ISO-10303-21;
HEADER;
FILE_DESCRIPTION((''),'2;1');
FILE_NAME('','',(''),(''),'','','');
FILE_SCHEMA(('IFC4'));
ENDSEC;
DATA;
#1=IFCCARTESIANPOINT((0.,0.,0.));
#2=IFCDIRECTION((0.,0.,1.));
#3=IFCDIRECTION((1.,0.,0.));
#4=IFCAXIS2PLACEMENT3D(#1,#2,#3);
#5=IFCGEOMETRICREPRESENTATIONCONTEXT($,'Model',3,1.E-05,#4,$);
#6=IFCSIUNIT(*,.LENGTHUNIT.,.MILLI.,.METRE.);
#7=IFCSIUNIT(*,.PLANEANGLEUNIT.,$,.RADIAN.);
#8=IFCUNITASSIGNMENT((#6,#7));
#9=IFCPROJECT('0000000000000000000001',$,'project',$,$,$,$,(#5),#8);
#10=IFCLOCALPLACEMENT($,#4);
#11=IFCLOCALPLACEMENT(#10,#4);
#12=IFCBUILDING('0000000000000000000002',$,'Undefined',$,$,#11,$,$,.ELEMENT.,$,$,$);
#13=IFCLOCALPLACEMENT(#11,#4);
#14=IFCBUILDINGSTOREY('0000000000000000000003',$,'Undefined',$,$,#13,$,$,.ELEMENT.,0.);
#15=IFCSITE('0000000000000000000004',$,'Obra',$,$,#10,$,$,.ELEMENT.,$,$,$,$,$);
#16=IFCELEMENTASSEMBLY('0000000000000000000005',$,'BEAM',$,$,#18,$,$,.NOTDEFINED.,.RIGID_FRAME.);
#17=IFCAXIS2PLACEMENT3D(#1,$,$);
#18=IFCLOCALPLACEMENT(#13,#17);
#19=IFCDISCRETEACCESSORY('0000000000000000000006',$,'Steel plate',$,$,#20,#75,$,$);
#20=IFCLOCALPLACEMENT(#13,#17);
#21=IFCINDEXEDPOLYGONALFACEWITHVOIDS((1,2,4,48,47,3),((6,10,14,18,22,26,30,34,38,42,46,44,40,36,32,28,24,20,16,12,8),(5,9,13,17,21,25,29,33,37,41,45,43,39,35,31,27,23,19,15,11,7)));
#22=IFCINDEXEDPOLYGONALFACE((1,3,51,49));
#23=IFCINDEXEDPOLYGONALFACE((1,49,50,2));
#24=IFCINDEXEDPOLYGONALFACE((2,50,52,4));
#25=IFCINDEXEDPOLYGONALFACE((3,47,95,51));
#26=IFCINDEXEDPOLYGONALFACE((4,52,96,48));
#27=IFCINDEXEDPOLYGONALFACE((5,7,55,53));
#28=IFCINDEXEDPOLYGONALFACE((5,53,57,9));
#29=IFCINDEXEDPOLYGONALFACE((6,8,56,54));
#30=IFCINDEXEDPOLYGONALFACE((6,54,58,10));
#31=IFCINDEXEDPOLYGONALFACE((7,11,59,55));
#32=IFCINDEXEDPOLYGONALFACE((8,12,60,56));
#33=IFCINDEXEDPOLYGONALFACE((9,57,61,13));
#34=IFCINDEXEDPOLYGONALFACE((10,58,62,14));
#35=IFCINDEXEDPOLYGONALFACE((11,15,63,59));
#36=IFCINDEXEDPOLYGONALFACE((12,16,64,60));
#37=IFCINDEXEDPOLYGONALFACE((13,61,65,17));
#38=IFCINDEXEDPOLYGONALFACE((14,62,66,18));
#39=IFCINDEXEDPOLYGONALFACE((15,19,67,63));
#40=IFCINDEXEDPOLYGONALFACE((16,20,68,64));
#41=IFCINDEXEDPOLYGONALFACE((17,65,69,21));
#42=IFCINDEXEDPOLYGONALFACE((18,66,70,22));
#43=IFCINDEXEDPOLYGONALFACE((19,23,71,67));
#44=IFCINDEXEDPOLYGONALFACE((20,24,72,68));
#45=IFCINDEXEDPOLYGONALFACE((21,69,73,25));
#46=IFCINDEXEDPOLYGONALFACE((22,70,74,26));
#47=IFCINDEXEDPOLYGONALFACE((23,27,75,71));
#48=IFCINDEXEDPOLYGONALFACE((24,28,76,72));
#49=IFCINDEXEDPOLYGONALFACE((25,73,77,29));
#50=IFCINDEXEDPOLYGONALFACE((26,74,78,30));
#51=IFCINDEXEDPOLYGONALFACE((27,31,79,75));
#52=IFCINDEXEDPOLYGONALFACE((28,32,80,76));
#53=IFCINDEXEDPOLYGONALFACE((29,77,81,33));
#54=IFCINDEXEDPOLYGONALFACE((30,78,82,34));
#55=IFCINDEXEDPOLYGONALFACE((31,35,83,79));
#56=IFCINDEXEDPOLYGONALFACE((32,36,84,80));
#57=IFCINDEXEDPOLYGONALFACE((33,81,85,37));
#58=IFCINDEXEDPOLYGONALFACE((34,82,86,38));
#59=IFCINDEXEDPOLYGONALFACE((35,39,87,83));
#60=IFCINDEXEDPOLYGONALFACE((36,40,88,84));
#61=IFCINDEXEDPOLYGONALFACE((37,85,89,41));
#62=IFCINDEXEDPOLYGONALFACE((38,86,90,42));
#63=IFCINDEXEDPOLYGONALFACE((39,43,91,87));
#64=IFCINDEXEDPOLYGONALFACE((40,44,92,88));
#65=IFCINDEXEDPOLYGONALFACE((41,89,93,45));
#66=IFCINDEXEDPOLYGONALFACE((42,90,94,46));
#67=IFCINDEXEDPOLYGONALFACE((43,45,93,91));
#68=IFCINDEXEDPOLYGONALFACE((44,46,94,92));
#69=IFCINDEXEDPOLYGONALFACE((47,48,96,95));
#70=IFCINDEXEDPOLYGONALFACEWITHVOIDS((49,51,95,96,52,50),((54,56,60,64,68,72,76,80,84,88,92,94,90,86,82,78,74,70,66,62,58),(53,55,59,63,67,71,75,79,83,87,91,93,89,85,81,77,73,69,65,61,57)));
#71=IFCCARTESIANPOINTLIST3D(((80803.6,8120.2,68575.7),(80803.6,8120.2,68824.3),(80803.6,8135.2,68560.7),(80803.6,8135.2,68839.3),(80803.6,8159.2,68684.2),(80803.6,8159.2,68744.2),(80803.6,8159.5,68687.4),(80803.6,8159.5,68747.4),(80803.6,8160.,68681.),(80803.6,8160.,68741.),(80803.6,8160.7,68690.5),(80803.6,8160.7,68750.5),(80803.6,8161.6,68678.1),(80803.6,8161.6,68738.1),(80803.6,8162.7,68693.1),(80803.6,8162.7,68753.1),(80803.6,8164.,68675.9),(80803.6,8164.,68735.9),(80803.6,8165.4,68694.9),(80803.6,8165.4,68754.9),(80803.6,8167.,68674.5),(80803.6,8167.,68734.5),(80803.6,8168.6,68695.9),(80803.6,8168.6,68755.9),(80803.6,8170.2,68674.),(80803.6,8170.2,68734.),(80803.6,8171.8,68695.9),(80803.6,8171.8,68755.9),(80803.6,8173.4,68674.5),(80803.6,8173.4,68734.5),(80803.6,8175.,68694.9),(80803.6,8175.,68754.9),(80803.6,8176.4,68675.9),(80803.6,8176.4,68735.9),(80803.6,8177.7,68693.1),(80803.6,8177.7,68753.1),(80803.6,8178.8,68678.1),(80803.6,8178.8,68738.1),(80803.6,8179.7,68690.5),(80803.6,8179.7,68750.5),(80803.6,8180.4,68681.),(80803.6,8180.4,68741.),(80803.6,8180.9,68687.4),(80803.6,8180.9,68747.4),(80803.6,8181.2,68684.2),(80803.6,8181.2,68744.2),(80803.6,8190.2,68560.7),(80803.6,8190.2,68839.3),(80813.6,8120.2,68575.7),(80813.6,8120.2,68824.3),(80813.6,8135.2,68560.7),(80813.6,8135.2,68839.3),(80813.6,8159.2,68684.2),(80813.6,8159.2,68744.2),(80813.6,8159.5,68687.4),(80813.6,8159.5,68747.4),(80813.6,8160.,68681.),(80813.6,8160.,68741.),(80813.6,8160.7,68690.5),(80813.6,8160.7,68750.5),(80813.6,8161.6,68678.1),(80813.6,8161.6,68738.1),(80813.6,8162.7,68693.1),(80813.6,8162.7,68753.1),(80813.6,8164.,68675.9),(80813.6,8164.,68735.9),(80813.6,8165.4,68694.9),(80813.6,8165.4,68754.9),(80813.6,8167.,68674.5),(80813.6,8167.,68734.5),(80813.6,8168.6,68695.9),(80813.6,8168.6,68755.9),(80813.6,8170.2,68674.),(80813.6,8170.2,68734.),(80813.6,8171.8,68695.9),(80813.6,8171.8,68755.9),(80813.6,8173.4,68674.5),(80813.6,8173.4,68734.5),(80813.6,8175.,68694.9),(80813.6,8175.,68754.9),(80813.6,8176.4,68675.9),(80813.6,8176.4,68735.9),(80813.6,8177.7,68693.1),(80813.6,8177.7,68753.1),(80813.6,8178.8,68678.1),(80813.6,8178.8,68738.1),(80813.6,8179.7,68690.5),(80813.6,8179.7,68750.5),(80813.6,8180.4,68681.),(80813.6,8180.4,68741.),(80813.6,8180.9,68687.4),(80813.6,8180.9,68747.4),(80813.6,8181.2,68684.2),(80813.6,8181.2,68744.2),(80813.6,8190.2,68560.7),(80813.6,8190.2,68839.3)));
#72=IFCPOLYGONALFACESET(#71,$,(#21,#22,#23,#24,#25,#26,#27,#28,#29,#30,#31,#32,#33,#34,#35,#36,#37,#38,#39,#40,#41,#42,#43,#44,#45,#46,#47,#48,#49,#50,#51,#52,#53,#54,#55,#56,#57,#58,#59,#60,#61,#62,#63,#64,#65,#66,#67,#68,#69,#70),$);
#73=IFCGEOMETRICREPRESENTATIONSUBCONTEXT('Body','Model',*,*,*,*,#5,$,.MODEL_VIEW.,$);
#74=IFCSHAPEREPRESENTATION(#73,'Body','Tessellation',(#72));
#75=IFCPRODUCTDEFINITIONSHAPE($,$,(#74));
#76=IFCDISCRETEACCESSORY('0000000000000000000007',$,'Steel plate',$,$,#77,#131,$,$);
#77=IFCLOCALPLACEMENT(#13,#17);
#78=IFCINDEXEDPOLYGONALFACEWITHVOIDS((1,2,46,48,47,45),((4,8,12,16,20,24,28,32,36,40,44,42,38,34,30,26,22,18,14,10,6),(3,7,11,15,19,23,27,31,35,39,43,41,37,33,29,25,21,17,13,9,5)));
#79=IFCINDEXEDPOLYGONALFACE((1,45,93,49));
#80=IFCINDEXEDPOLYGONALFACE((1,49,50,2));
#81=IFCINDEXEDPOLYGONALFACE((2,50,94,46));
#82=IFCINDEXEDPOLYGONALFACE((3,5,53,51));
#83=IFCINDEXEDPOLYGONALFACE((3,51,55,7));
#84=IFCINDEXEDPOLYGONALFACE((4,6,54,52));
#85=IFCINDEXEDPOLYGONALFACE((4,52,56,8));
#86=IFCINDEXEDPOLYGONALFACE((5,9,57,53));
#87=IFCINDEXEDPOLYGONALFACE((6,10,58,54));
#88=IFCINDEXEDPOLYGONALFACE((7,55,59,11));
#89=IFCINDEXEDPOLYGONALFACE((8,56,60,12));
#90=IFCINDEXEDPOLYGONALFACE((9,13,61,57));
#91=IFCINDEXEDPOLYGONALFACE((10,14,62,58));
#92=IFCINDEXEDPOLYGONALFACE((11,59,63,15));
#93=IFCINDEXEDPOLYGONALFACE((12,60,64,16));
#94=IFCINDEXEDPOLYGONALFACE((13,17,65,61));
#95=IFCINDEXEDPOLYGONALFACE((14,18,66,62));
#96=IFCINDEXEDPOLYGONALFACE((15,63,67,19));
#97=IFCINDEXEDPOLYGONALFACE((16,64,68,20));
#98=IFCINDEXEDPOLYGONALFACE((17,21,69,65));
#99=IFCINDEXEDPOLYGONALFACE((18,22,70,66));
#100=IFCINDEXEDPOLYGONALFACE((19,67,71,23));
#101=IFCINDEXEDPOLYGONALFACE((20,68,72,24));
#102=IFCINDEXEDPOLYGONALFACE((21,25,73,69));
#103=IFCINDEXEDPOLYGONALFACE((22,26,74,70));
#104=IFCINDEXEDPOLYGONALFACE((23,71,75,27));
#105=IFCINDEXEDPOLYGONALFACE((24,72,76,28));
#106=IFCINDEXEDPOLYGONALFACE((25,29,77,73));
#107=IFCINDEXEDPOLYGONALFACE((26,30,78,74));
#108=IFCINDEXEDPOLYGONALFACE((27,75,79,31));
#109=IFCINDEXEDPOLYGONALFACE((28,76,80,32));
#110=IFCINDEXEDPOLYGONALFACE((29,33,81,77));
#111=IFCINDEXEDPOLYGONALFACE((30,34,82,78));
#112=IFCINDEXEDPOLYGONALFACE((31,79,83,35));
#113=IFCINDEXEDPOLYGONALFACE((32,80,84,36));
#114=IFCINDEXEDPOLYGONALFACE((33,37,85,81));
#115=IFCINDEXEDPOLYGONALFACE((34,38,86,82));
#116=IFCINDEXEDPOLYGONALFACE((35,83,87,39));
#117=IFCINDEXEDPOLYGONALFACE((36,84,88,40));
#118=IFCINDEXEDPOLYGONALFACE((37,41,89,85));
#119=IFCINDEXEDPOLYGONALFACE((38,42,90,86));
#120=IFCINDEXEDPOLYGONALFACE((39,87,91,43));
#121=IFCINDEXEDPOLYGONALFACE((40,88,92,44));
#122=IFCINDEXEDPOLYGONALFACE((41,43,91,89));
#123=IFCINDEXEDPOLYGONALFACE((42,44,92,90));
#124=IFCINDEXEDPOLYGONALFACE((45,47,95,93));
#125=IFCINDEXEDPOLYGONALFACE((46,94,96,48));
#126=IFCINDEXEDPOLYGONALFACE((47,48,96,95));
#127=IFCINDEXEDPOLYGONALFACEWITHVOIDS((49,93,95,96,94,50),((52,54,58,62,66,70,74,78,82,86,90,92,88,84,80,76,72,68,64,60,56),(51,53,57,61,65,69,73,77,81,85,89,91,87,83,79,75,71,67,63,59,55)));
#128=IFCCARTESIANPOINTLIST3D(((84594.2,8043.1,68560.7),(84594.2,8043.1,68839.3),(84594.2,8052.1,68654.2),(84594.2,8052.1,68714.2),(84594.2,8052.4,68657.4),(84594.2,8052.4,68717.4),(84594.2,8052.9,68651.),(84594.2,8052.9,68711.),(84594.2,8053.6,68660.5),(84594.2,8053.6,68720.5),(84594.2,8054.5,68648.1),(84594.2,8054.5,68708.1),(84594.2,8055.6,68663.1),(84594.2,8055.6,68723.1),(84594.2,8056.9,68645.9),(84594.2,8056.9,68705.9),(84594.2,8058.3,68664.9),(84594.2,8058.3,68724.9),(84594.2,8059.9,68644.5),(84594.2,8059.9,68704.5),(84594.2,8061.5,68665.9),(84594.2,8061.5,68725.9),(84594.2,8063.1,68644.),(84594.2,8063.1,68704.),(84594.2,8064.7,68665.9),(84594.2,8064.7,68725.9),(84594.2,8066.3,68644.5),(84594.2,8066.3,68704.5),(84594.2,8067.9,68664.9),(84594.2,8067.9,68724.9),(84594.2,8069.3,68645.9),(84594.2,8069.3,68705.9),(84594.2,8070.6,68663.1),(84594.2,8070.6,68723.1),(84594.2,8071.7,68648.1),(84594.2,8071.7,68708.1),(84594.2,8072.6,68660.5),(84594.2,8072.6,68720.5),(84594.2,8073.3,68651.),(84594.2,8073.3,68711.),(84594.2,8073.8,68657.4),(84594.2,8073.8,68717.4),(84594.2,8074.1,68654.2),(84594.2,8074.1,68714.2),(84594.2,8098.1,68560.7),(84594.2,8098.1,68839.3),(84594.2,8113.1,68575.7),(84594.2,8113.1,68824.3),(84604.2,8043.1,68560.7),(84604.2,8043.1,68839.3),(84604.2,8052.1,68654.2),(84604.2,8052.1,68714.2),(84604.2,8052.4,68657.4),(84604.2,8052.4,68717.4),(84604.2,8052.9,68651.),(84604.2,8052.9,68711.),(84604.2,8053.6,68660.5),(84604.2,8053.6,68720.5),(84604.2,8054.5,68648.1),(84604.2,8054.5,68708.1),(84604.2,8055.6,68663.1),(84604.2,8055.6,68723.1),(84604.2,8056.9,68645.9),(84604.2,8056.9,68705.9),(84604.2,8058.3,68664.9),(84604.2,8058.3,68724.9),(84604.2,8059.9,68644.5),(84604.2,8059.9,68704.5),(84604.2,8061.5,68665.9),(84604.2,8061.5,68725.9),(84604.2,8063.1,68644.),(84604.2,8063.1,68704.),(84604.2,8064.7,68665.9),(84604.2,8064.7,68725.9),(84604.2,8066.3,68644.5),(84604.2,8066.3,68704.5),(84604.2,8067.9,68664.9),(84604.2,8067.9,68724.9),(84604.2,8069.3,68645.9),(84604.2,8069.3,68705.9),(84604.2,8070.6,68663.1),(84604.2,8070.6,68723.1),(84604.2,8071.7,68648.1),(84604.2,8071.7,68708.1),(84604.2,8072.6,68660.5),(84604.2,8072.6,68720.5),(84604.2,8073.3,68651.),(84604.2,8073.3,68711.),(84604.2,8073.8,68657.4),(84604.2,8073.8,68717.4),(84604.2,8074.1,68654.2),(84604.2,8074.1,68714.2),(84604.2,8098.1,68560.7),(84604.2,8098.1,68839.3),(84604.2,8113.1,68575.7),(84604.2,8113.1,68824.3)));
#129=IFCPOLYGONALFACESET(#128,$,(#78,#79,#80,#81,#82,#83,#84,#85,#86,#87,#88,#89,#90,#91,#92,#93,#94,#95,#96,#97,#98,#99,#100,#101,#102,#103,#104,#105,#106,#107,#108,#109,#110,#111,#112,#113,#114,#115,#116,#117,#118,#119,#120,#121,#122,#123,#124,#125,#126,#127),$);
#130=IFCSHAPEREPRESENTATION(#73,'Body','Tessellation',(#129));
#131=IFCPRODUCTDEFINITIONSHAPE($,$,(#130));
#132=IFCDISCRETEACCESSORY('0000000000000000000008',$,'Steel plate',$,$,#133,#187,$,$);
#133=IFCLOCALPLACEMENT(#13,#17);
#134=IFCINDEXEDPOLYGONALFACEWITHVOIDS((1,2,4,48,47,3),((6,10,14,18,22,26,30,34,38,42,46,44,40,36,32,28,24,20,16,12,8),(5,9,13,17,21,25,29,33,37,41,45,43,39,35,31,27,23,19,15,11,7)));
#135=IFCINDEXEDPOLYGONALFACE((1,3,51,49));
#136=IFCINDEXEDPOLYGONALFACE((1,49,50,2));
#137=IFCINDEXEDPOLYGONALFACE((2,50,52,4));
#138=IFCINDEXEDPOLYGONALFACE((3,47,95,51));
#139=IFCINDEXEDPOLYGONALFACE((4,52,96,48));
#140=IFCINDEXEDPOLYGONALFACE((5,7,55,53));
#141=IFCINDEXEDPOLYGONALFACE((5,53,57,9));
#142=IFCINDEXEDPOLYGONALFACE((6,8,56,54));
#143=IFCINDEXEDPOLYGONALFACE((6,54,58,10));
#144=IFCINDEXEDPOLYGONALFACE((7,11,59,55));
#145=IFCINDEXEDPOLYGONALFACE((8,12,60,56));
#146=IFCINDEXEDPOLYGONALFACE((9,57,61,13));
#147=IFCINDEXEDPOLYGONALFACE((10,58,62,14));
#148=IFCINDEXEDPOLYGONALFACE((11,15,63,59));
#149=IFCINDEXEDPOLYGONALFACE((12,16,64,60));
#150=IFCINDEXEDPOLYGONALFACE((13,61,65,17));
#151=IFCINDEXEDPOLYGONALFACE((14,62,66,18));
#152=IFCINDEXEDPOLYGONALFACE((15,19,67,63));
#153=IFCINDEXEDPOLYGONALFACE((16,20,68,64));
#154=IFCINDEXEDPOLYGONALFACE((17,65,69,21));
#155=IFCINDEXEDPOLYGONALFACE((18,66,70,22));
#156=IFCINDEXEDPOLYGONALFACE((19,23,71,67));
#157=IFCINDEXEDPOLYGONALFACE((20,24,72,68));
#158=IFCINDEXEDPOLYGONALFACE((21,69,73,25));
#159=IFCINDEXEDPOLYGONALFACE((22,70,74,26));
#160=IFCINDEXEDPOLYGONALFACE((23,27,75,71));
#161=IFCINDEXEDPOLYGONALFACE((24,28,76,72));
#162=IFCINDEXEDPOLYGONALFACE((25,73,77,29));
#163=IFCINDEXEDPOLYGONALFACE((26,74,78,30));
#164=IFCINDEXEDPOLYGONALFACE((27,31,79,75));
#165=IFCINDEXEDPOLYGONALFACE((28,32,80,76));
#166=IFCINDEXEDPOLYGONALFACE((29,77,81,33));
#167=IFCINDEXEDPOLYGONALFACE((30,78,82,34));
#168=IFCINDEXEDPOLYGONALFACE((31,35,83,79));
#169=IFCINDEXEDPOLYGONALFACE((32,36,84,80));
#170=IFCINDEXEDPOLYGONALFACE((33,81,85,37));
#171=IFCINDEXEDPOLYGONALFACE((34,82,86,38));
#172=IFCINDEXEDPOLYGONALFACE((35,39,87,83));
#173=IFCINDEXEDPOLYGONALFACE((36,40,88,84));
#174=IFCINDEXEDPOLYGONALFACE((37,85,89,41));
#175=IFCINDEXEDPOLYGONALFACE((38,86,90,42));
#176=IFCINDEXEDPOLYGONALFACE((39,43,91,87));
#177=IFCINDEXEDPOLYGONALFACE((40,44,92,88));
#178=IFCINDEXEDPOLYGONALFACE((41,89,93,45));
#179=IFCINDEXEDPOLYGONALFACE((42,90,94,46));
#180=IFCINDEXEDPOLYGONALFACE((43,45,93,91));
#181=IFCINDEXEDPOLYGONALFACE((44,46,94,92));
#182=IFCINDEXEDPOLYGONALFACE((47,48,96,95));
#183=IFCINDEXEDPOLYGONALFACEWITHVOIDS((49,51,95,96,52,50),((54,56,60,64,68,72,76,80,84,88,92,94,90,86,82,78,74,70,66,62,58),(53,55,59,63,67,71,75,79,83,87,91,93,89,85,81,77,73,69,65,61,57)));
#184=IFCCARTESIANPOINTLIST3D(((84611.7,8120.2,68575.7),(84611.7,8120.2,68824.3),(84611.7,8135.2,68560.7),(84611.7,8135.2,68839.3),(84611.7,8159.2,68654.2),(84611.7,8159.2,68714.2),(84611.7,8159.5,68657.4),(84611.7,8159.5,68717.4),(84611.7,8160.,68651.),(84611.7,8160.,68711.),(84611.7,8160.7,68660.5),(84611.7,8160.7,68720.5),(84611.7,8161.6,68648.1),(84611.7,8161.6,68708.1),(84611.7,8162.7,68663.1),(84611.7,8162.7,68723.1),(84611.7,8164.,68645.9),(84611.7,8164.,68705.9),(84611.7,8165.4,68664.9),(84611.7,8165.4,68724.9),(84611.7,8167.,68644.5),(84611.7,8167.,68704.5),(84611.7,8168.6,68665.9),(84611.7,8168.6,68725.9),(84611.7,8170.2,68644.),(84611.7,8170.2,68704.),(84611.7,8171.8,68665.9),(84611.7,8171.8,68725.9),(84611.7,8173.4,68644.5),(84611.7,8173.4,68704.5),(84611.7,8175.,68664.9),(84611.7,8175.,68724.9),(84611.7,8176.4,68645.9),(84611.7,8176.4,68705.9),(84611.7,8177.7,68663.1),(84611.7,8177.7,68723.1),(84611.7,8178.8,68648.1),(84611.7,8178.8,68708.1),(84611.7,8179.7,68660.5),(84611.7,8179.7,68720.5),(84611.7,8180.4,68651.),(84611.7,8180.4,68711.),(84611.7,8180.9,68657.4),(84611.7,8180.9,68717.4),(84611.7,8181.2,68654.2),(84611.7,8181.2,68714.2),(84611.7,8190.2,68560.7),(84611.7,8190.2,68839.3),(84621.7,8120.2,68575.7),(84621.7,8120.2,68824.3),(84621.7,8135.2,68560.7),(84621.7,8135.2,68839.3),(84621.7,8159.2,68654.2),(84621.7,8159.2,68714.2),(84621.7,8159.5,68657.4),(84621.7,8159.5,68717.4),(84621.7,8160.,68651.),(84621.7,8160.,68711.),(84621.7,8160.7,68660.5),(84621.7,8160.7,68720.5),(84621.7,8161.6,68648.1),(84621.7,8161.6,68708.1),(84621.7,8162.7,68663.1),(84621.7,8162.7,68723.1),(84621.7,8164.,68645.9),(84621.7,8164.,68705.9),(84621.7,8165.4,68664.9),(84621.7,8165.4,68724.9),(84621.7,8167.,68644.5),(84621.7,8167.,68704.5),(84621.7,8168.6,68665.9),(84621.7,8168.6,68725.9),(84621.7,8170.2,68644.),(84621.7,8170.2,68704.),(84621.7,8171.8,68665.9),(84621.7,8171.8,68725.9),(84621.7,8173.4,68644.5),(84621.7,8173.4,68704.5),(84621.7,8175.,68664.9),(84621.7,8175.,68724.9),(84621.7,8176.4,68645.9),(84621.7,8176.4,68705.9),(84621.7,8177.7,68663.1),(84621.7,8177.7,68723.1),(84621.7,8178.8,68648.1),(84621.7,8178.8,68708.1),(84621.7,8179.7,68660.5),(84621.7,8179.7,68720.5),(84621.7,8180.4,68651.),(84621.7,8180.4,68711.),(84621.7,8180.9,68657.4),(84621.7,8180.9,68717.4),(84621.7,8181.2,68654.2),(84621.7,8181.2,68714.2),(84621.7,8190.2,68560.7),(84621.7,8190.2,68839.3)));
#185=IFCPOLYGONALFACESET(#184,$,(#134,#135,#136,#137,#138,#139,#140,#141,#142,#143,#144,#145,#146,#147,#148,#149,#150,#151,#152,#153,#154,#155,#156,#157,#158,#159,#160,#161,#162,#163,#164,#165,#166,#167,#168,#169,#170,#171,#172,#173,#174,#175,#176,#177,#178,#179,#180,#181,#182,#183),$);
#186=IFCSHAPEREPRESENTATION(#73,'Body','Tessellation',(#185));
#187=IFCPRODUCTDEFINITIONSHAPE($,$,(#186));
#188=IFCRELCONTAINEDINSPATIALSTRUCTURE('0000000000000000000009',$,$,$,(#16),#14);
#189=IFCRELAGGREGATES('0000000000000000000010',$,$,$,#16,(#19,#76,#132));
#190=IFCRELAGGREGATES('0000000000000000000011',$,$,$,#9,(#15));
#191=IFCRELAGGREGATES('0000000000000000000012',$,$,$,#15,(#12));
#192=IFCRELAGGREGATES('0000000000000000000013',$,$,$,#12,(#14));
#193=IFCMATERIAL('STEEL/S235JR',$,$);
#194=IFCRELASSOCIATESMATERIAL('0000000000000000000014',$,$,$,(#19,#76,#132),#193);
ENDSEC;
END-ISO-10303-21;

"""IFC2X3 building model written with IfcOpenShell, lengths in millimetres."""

from ifc_helpers import new_model, si_unit, frame, origin_with_axes, origin_2d_with_axis, place, context, subcontext, project, spatial, polyline, circle, outline, extrude, source, transform, mapped, material, element, aggregate, save


model = new_model("IFC2X3")

# Units and contexts
model_context = context("Model", 3, precision=1e-05, world=origin_with_axes())
body_context = subcontext(model_context, "Body", "Model", "MODEL_VIEW")
ifc_project = project(units=[si_unit("LENGTHUNIT", "METRE", prefix="MILLI"), si_unit("PLANEANGLEUNIT", "RADIAN")], contexts=[model_context])

# Site, building, storey
site_placement = place(None, origin_with_axes())
site = spatial("IfcSite", under=ifc_project, at=site_placement, Name="Obra", CompositionType="ELEMENT")
building_placement = place(site_placement, origin_with_axes())
building = spatial("IfcBuilding", under=site, at=building_placement, Name="Undefined", CompositionType="ELEMENT")
storey_placement = place(building_placement, origin_with_axes())
storey = spatial("IfcBuildingStorey", under=building, at=storey_placement, Name="Undefined", CompositionType="ELEMENT", Elevation=0.0)

# Shared definitions
ifc_material = material(Name="STEEL/S235JR")

# Element assembly
assembly_1_placement = place(storey_placement, origin_with_axes())
assembly_1 = element("IfcElementAssembly", 1, at=assembly_1_placement, inside=storey, Name="BEAM", AssemblyPlace="NOTDEFINED", PredefinedType="RIGID_FRAME")
shared_shape_1 = source(origin_with_axes(), body_context, "Body", "SweptSolid", [
    extrude(circle(Radius=11.0, at=origin_2d_with_axis()), frame((0.0, -13.4, 0.0), z_axis=(0.0, 1.0, 0.0), x_axis=(1.0, 0.0, 0.0)), (0.0, 0.0, 1.0), 10.2),
])

# Discrete accessories, openings
discrete_accessory_1_placement = place(assembly_1_placement, frame((80808.6, 8190.2, 68560.7), z_axis=(-1.0, 0.0, 0.0), x_axis=(0.0, -1.0, 0.0)))
discrete_accessory_1 = element("IfcDiscreteAccessory", 2, at=discrete_accessory_1_placement, material=ifc_material, Name="Steel plate", context=body_context, shape_type="SweptSolid", body=[
    extrude(outline(polyline([(0.0, 0.0), (55.0, 0.0), (70.0, 15.0), (70.0, 263.6), (55.0, 278.6), (0.0, 278.6), (0.0, 0.0)])), frame((0.0, 0.0, -5.0), z_axis=(0.0, 0.0, 1.0), x_axis=(1.0, 0.0, 0.0)), (0.0, 0.0, 1.0), 10.0),
])
opening_1_placement = place(assembly_1_placement, frame((80800.3, 8130.2, 68850.0), z_axis=(0.0, 1.0, 0.0), x_axis=(0.0, 0.0, -1.0)))
element("IfcOpeningElement", 3, at=opening_1_placement, cuts=discrete_accessory_1, ObjectType="Opening", context=body_context, shape_type="MappedRepresentation", body=[
    mapped(shared_shape_1, transform((105.0, 0.0, 40.0))),
    mapped(shared_shape_1, transform((165.0, 0.0, 40.0))),
])
discrete_accessory_2_placement = place(assembly_1_placement, frame((84599.2, 8043.1, 68560.7), z_axis=(1.0, 0.0, 0.0), x_axis=(0.0, 1.0, 0.0)))
discrete_accessory_2 = element("IfcDiscreteAccessory", 4, at=discrete_accessory_2_placement, material=ifc_material, Name="Steel plate", context=body_context, shape_type="SweptSolid", body=[
    extrude(outline(polyline([(0.0, 0.0), (55.0, 0.0), (70.0, 15.0), (70.0, 263.6), (55.0, 278.6), (0.0, 278.6), (0.0, 0.0)])), frame((0.0, 0.0, -5.0), z_axis=(0.0, 0.0, 1.0), x_axis=(1.0, 0.0, 0.0)), (0.0, 0.0, 1.0), 10.0),
])
shared_shape_2 = source(origin_with_axes(), body_context, "Body", "SweptSolid", [
    extrude(circle(Radius=11.0, at=origin_2d_with_axis()), frame((0.0, -13.9, 0.0), z_axis=(0.0, 1.0, 0.0), x_axis=(1.0, 0.0, 0.0)), (0.0, 0.0, 1.0), 10.2),
])
opening_2_placement = place(assembly_1_placement, frame((84607.9, 8103.1, 68850.0), z_axis=(0.0, -1.0, 0.0), x_axis=(0.0, 0.0, -1.0)))
element("IfcOpeningElement", 5, at=opening_2_placement, cuts=discrete_accessory_2, ObjectType="Opening", context=body_context, shape_type="MappedRepresentation", body=[
    mapped(shared_shape_2, transform((135.0, 0.0, 40.0))),
    mapped(shared_shape_2, transform((195.0, 0.0, 40.0))),
])
discrete_accessory_3_placement = place(assembly_1_placement, frame((84616.7, 8190.2, 68560.7), z_axis=(-1.0, 0.0, 0.0), x_axis=(0.0, -1.0, 0.0)))
discrete_accessory_3 = element("IfcDiscreteAccessory", 6, at=discrete_accessory_3_placement, material=ifc_material, Name="Steel plate", context=body_context, shape_type="SweptSolid", body=[
    extrude(outline(polyline([(0.0, 0.0), (55.0, 0.0), (70.0, 15.0), (70.0, 263.6), (55.0, 278.6), (0.0, 278.6), (0.0, 0.0)])), frame((0.0, 0.0, -5.0), z_axis=(0.0, 0.0, 1.0), x_axis=(1.0, 0.0, 0.0)), (0.0, 0.0, 1.0), 10.0),
])
opening_3_placement = place(assembly_1_placement, frame((84607.9, 8130.2, 68850.0), z_axis=(0.0, 1.0, 0.0), x_axis=(0.0, 0.0, -1.0)))
element("IfcOpeningElement", 7, at=opening_3_placement, cuts=discrete_accessory_3, ObjectType="Opening", context=body_context, shape_type="MappedRepresentation", body=[
    mapped(shared_shape_2, transform((135.0, 0.0, 40.0))),
    mapped(shared_shape_2, transform((195.0, 0.0, 40.0))),
])
aggregate(assembly_1, [discrete_accessory_1, discrete_accessory_2, discrete_accessory_3])

save(model, "model.ifc")
